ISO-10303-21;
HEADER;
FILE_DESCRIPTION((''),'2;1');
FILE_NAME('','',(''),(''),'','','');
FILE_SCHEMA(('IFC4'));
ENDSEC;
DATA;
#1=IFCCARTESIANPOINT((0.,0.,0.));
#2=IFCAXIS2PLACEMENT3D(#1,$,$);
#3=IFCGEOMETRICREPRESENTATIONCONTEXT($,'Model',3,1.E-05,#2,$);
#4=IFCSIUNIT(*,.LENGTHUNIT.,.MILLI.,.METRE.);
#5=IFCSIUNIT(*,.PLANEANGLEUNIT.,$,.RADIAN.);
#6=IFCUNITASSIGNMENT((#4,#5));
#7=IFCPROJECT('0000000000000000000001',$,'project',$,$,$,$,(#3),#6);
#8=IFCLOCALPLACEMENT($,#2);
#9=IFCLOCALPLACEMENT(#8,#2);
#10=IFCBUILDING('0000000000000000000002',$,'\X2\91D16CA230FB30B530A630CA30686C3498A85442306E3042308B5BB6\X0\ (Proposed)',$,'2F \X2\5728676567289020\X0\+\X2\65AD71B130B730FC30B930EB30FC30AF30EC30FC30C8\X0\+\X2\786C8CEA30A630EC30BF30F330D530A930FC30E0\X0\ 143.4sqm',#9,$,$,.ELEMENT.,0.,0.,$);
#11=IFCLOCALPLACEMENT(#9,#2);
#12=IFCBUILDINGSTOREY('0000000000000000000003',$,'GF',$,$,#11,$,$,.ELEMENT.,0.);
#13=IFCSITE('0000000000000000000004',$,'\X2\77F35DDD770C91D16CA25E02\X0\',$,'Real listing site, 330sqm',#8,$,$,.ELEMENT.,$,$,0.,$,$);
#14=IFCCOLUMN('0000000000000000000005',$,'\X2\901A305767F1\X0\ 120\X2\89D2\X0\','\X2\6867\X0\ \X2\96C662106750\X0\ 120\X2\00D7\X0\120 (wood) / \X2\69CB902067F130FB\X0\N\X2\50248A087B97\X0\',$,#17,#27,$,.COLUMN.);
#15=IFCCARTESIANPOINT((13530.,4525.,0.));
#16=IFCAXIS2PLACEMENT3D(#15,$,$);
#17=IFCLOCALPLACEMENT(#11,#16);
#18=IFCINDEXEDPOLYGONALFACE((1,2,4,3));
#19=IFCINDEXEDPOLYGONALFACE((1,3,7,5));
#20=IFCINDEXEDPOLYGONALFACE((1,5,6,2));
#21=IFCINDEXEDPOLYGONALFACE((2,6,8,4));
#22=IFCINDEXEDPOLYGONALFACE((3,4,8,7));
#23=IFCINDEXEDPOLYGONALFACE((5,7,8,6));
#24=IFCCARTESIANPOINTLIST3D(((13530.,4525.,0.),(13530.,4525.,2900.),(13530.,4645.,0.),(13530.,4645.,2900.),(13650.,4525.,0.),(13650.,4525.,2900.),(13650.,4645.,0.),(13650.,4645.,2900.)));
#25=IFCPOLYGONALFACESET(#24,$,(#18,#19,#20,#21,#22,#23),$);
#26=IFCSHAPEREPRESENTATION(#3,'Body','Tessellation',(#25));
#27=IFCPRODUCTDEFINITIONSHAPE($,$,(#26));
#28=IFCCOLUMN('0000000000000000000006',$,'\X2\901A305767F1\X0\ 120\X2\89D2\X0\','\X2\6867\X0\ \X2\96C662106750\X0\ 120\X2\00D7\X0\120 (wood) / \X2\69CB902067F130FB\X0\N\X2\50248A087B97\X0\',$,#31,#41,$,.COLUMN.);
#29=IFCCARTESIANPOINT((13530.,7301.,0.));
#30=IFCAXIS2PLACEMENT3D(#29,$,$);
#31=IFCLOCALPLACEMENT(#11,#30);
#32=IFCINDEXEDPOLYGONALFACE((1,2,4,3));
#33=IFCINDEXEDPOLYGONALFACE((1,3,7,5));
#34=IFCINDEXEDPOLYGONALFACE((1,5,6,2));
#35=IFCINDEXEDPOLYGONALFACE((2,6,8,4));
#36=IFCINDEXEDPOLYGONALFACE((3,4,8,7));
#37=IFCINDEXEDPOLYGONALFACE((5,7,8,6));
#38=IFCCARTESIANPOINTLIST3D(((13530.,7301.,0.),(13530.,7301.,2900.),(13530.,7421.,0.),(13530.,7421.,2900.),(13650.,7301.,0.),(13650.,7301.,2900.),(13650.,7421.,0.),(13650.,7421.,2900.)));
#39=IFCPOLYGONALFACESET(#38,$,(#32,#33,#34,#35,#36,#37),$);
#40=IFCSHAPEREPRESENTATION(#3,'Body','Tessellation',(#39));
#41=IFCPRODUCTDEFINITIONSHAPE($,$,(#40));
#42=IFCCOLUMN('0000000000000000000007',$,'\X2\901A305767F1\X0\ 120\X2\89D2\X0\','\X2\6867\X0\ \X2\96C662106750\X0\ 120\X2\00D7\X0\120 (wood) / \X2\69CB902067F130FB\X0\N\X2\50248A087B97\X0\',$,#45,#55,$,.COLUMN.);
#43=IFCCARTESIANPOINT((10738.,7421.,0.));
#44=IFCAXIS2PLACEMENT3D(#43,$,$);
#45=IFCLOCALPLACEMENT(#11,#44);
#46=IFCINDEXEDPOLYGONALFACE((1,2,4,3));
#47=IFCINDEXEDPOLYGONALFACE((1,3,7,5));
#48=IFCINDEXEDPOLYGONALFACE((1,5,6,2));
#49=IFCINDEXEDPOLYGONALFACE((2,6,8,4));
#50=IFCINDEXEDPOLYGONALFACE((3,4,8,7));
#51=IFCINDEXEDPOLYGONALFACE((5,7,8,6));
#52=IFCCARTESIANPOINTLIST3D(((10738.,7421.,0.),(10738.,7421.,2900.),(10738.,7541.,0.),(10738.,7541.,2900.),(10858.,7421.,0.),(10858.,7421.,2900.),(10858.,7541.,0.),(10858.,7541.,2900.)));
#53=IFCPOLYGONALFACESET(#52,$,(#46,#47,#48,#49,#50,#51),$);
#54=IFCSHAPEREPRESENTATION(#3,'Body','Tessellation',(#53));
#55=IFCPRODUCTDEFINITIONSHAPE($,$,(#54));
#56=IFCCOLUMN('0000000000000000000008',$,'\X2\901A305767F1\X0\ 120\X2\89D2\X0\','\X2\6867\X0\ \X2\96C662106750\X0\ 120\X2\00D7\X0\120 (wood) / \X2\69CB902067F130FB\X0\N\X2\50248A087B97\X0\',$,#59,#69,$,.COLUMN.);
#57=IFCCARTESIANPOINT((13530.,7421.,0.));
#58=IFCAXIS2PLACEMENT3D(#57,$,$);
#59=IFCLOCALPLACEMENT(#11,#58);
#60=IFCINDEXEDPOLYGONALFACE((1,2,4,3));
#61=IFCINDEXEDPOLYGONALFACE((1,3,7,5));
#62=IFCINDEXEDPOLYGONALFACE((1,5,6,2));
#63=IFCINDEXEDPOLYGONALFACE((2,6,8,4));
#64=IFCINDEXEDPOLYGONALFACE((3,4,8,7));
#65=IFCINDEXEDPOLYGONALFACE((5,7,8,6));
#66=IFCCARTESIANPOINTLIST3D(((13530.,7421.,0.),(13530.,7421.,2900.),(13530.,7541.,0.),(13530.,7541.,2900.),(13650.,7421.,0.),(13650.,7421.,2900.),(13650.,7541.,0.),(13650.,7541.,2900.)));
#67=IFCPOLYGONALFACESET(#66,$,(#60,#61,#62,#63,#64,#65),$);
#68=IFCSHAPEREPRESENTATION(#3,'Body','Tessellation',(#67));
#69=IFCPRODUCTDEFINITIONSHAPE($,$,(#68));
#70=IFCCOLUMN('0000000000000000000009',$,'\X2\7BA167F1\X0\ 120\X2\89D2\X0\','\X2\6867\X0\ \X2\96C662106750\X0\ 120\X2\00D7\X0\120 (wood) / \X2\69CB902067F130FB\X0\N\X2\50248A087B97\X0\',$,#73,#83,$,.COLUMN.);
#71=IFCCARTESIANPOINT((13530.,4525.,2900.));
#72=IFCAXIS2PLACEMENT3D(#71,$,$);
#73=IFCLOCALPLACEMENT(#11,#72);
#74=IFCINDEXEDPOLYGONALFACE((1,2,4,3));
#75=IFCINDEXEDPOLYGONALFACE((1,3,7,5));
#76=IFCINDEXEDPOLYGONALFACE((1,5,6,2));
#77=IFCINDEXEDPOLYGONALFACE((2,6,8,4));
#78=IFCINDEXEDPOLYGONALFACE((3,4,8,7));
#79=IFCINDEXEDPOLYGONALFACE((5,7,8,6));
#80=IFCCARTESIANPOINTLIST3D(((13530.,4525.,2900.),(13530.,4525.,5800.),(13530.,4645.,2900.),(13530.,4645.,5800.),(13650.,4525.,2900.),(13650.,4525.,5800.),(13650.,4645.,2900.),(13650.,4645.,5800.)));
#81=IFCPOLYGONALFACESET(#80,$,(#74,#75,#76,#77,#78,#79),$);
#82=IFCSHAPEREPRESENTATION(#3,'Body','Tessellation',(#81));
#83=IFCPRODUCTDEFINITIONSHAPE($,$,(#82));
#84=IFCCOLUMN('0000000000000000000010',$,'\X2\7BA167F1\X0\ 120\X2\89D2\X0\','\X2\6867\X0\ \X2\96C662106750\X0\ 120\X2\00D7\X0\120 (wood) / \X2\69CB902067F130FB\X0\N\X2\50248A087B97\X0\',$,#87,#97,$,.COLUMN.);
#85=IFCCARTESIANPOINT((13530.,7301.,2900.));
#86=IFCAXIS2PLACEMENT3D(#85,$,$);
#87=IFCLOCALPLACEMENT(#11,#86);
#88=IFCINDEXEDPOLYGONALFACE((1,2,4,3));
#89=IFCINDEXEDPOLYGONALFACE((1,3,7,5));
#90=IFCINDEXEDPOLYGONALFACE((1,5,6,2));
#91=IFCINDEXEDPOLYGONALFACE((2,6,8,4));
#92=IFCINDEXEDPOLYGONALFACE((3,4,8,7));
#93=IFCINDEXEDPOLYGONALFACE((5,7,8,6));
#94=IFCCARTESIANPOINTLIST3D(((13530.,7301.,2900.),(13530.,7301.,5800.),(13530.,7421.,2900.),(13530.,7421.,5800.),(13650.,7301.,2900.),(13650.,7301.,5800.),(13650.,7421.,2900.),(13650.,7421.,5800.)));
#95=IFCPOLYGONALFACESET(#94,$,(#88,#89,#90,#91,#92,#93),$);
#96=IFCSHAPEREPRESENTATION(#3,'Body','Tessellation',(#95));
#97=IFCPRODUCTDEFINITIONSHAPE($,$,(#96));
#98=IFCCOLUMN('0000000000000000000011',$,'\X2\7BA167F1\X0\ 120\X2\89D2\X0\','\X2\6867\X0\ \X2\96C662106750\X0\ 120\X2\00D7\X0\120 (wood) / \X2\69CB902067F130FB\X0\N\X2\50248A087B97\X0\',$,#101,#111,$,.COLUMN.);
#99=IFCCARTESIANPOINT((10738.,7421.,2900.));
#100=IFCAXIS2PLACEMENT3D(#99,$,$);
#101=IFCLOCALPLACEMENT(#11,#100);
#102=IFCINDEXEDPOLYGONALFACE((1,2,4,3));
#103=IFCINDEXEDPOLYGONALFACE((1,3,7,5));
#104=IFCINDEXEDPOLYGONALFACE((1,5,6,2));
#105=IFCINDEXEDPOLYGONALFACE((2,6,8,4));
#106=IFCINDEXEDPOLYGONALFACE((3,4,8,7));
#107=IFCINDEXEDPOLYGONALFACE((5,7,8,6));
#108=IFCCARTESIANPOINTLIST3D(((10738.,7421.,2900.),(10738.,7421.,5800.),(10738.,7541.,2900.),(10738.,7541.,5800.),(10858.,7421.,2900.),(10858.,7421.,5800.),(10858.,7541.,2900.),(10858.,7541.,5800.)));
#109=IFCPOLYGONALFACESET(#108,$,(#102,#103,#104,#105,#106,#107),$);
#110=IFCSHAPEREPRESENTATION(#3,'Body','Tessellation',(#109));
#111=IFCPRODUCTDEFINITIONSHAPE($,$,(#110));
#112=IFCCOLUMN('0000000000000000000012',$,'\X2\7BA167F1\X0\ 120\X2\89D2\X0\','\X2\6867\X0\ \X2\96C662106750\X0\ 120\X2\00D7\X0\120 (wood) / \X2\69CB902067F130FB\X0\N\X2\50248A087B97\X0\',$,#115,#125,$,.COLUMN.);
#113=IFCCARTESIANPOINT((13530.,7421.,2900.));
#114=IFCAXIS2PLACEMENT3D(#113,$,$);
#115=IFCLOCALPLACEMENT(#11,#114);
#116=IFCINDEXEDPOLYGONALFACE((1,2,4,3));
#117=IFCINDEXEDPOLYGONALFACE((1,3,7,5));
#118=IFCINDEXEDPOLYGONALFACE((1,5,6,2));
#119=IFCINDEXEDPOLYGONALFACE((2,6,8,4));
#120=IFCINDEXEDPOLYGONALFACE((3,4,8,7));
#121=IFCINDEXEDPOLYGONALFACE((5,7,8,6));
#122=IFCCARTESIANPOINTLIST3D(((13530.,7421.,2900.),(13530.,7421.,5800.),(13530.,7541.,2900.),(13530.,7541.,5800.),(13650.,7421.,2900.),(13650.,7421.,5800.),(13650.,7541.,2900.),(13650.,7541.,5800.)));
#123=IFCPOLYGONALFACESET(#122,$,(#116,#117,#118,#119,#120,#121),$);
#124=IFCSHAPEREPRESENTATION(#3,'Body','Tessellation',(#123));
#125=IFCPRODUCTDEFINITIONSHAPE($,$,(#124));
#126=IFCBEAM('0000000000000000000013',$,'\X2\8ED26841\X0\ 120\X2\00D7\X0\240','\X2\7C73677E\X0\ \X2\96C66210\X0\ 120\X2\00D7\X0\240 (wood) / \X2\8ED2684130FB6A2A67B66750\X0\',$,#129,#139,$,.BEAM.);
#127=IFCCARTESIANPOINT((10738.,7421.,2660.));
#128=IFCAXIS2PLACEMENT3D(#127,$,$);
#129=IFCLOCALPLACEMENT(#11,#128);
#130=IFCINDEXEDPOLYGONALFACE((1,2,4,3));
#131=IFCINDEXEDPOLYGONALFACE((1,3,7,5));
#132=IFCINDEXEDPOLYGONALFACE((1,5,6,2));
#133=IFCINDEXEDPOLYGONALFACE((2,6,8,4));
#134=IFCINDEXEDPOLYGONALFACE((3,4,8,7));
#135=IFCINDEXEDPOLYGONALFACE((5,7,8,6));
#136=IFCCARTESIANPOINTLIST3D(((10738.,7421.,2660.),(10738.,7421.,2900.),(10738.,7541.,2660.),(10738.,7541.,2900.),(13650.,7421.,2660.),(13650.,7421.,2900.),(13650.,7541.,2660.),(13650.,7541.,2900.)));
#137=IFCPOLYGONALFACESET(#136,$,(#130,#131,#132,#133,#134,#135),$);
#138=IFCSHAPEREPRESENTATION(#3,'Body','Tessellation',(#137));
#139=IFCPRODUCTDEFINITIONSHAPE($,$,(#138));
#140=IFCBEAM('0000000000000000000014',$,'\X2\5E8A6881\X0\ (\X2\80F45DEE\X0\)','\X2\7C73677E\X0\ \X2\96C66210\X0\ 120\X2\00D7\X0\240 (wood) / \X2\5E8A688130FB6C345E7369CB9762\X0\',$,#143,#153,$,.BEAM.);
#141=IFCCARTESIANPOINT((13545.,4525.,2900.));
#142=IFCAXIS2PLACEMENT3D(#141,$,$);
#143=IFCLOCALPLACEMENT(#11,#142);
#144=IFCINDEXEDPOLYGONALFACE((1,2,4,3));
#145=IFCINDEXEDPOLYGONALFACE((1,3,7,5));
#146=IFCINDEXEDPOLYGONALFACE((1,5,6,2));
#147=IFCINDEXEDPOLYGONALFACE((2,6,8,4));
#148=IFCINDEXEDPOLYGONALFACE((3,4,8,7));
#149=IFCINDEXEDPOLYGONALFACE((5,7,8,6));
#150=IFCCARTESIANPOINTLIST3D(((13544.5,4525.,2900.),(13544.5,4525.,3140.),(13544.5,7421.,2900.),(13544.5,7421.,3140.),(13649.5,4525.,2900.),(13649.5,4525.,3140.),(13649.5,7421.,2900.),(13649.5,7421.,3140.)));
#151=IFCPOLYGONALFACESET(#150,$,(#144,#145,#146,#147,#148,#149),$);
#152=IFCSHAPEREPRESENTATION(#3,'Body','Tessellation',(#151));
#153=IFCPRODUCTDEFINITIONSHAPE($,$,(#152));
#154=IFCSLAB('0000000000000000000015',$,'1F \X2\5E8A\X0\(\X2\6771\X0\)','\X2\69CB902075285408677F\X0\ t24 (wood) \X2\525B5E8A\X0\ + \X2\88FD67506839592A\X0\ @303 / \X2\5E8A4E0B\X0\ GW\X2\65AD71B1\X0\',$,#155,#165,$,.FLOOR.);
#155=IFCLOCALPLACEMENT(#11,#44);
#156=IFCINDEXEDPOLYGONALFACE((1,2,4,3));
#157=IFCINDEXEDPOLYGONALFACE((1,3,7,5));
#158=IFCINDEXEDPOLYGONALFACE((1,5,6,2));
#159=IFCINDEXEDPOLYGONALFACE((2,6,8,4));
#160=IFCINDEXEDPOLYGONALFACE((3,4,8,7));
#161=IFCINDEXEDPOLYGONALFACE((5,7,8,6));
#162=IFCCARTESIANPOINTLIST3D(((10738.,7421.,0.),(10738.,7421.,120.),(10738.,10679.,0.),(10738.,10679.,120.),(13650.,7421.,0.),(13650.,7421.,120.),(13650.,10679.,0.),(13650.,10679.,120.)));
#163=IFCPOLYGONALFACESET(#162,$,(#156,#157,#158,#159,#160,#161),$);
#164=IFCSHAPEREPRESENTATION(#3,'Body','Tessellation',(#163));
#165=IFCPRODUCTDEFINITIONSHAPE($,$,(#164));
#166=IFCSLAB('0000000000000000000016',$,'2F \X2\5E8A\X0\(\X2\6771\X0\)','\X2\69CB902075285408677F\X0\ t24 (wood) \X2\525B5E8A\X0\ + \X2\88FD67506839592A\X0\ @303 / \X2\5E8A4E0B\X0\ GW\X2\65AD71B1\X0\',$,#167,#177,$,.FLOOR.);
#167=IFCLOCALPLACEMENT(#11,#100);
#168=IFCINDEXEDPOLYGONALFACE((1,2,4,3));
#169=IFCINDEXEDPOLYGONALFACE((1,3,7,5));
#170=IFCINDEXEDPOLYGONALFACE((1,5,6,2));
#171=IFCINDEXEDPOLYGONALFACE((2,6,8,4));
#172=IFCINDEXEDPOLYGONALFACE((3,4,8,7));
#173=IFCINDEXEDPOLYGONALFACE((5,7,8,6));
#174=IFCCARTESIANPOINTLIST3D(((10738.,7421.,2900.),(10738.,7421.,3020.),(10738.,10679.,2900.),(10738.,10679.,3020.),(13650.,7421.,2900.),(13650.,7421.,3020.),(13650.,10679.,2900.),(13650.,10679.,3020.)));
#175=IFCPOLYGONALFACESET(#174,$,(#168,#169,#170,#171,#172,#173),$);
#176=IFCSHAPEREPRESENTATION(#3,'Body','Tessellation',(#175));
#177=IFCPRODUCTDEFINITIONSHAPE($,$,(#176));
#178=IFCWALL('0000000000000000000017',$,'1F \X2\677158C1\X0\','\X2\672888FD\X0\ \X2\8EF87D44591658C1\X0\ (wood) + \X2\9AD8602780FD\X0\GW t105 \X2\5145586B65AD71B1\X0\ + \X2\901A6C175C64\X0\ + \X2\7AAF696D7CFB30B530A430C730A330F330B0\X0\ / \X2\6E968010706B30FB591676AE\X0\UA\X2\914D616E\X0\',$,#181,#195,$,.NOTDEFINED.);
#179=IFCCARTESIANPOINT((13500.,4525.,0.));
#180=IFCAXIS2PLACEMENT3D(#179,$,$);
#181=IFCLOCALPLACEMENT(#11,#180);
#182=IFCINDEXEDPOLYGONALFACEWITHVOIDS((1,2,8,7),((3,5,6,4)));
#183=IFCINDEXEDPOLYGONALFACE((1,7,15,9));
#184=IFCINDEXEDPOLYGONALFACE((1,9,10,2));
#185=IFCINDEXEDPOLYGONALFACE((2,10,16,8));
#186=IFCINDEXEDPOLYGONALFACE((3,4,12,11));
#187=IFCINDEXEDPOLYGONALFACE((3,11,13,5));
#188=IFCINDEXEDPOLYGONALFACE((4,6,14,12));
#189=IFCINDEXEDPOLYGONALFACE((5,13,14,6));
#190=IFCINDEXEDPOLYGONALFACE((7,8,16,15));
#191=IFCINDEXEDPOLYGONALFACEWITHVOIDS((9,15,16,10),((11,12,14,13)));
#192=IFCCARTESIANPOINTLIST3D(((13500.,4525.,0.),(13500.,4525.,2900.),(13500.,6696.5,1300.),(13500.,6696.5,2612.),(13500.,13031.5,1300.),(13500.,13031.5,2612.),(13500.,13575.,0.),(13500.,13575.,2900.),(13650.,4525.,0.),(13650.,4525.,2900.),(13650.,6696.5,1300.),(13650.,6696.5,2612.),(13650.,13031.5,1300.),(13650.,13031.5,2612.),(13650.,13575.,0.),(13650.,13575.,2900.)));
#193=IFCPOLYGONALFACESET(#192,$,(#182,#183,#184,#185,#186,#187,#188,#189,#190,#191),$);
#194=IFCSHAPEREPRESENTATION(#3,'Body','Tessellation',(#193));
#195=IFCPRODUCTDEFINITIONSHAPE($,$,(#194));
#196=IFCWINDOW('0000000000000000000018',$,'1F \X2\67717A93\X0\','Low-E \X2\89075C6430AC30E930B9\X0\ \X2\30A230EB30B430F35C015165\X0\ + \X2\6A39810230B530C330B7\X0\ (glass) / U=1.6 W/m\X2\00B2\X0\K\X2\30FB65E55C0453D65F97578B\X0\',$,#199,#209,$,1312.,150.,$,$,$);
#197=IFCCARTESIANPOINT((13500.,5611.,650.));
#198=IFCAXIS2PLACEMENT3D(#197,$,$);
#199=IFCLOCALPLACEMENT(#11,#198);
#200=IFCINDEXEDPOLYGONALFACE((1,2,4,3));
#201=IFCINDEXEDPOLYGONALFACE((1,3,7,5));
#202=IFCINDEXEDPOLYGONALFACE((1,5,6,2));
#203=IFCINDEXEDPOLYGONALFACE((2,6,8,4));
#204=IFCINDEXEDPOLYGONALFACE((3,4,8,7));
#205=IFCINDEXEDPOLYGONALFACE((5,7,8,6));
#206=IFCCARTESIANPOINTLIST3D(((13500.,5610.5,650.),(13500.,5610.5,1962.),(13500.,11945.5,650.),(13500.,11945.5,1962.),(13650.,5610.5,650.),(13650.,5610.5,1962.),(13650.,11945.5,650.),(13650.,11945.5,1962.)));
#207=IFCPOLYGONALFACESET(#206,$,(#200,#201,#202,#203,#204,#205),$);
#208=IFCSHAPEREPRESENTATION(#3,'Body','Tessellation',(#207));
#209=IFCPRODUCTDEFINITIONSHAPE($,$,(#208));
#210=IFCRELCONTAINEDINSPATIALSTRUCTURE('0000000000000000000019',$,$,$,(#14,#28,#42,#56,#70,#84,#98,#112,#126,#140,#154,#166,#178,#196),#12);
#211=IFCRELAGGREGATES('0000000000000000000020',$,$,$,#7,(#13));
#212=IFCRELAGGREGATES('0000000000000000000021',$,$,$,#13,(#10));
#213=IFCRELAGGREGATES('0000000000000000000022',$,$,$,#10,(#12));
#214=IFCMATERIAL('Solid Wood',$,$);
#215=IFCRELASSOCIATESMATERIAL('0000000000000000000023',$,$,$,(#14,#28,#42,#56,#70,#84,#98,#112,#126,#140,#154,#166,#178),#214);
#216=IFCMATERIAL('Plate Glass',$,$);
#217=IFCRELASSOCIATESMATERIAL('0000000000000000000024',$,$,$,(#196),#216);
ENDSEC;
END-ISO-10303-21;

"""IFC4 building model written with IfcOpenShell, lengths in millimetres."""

from ifc_helpers import new_model, si_unit, frame, frame_2d, origin, place, context, project, spatial, rectangle, extrude, material, element, fill, save


model = new_model("IFC4")

# Units and contexts
model_context = context("Model", 3, precision=1e-05, world=origin())
ifc_project = project(units=[si_unit("LENGTHUNIT", "METRE", prefix="MILLI"), si_unit("PLANEANGLEUNIT", "RADIAN")], contexts=[model_context])

# Site, building, storey
site_placement = place(None, origin())
site = spatial("IfcSite", under=ifc_project, at=site_placement, Name="石川県金沢市", ObjectType="Real listing site, 330sqm", CompositionType="ELEMENT", RefElevation=0.0)
building_placement = place(site_placement, origin())
building = spatial("IfcBuilding", under=site, at=building_placement, Name="金沢・サウナと水風呂のある家 (Proposed)", ObjectType="2F 在来木造+断熱シースルークレート+硬質ウレタンフォーム 143.4sqm", CompositionType="ELEMENT", ElevationOfRefHeight=0.0, ElevationOfTerrain=0.0)
storey_placement = place(building_placement, origin())
storey = spatial("IfcBuildingStorey", under=building, at=storey_placement, Name="GF", CompositionType="ELEMENT", Elevation=0.0)

# Columns
ifc_material_1 = material(Name="Solid Wood")
column_1_placement = place(storey_placement, frame((13530.0, 4525.0, 0.0)))
element("IfcColumn", 1, at=column_1_placement, inside=storey, material=ifc_material_1, Name="通し柱 120角", Description="桧 集成材 120×120 (wood) / 構造柱・N値計算", PredefinedType="COLUMN", context=model_context, shape_type="SweptSolid", body=[
    extrude(rectangle(XDim=120.0, YDim=120.0, at=frame_2d((60.0, 60.0))), frame((13530.0, 4525.0, 0.0)), (0.0, 0.0, 1.0), 2900.0),
])
column_2_placement = place(storey_placement, frame((13530.0, 7301.0, 0.0)))
element("IfcColumn", 2, at=column_2_placement, inside=storey, material=ifc_material_1, Name="通し柱 120角", Description="桧 集成材 120×120 (wood) / 構造柱・N値計算", PredefinedType="COLUMN", context=model_context, shape_type="SweptSolid", body=[
    extrude(rectangle(XDim=120.0, YDim=120.0, at=frame_2d((60.0, 60.0))), frame((13530.0, 7301.0, 0.0)), (0.0, 0.0, 1.0), 2900.0),
])
column_3_placement = place(storey_placement, frame((10738.0, 7421.0, 0.0)))
element("IfcColumn", 3, at=column_3_placement, inside=storey, material=ifc_material_1, Name="通し柱 120角", Description="桧 集成材 120×120 (wood) / 構造柱・N値計算", PredefinedType="COLUMN", context=model_context, shape_type="SweptSolid", body=[
    extrude(rectangle(XDim=120.0, YDim=120.0, at=frame_2d((60.0, 60.0))), frame((10738.0, 7421.0, 0.0)), (0.0, 0.0, 1.0), 2900.0),
])
column_4_placement = place(storey_placement, frame((13530.0, 7421.0, 0.0)))
element("IfcColumn", 4, at=column_4_placement, inside=storey, material=ifc_material_1, Name="通し柱 120角", Description="桧 集成材 120×120 (wood) / 構造柱・N値計算", PredefinedType="COLUMN", context=model_context, shape_type="SweptSolid", body=[
    extrude(rectangle(XDim=120.0, YDim=120.0, at=frame_2d((60.0, 60.0))), frame((13530.0, 7421.0, 0.0)), (0.0, 0.0, 1.0), 2900.0),
])
column_5_placement = place(storey_placement, frame((13530.0, 4525.0, 2900.0)))
element("IfcColumn", 5, at=column_5_placement, inside=storey, material=ifc_material_1, Name="管柱 120角", Description="桧 集成材 120×120 (wood) / 構造柱・N値計算", PredefinedType="COLUMN", context=model_context, shape_type="SweptSolid", body=[
    extrude(rectangle(XDim=120.0, YDim=120.0, at=frame_2d((60.0, 60.0))), frame((13530.0, 4525.0, 2900.0)), (0.0, 0.0, 1.0), 2900.0),
])
column_6_placement = place(storey_placement, frame((13530.0, 7301.0, 2900.0)))
element("IfcColumn", 6, at=column_6_placement, inside=storey, material=ifc_material_1, Name="管柱 120角", Description="桧 集成材 120×120 (wood) / 構造柱・N値計算", PredefinedType="COLUMN", context=model_context, shape_type="SweptSolid", body=[
    extrude(rectangle(XDim=120.0, YDim=120.0, at=frame_2d((60.0, 60.0))), frame((13530.0, 7301.0, 2900.0)), (0.0, 0.0, 1.0), 2900.0),
])
column_7_placement = place(storey_placement, frame((10738.0, 7421.0, 2900.0)))
element("IfcColumn", 7, at=column_7_placement, inside=storey, material=ifc_material_1, Name="管柱 120角", Description="桧 集成材 120×120 (wood) / 構造柱・N値計算", PredefinedType="COLUMN", context=model_context, shape_type="SweptSolid", body=[
    extrude(rectangle(XDim=120.0, YDim=120.0, at=frame_2d((60.0, 60.0))), frame((10738.0, 7421.0, 2900.0)), (0.0, 0.0, 1.0), 2900.0),
])
column_8_placement = place(storey_placement, frame((13530.0, 7421.0, 2900.0)))
element("IfcColumn", 8, at=column_8_placement, inside=storey, material=ifc_material_1, Name="管柱 120角", Description="桧 集成材 120×120 (wood) / 構造柱・N値計算", PredefinedType="COLUMN", context=model_context, shape_type="SweptSolid", body=[
    extrude(rectangle(XDim=120.0, YDim=120.0, at=frame_2d((60.0, 60.0))), frame((13530.0, 7421.0, 2900.0)), (0.0, 0.0, 1.0), 2900.0),
])

# Beams
beam_1_placement = place(storey_placement, frame((10738.0, 7421.0, 2660.0)))
element("IfcBeam", 9, at=beam_1_placement, inside=storey, material=ifc_material_1, Name="軒桁 120×240", Description="米松 集成 120×240 (wood) / 軒桁・横架材", PredefinedType="BEAM", context=model_context, shape_type="SweptSolid", body=[
    extrude(rectangle(XDim=2912.0, YDim=120.0, at=frame_2d((1456.0, 60.0))), frame((10738.0, 7421.0, 2660.0)), (0.0, 0.0, 1.0), 240.0),
])
beam_2_placement = place(storey_placement, frame((13545.0, 4525.0, 2900.0)))
element("IfcBeam", 10, at=beam_2_placement, inside=storey, material=ifc_material_1, Name="床梁 (胴差)", Description="米松 集成 120×240 (wood) / 床梁・水平構面", PredefinedType="BEAM", context=model_context, shape_type="SweptSolid", body=[
    extrude(rectangle(XDim=105.0, YDim=2896.0, at=frame_2d((52.0, 1448.0))), frame((13545.0, 4525.0, 2900.0)), (0.0, 0.0, 1.0), 240.0),
])

# Slabs
slab_1_placement = place(storey_placement, frame((10738.0, 7421.0, 0.0)))
element("IfcSlab", 11, at=slab_1_placement, inside=storey, material=ifc_material_1, Name="1F 床(東)", Description="構造用合板 t24 (wood) 剛床 + 製材根太 @303 / 床下 GW断熱", PredefinedType="FLOOR", context=model_context, shape_type="SweptSolid", body=[
    extrude(rectangle(XDim=2912.0, YDim=3258.0, at=frame_2d((1456.0, 1629.0))), frame((10738.0, 7421.0, 0.0)), (0.0, 0.0, 1.0), 120.0),
])
slab_2_placement = place(storey_placement, frame((10738.0, 7421.0, 2900.0)))
element("IfcSlab", 12, at=slab_2_placement, inside=storey, material=ifc_material_1, Name="2F 床(東)", Description="構造用合板 t24 (wood) 剛床 + 製材根太 @303 / 床下 GW断熱", PredefinedType="FLOOR", context=model_context, shape_type="SweptSolid", body=[
    extrude(rectangle(XDim=2912.0, YDim=3258.0, at=frame_2d((1456.0, 1629.0))), frame((10738.0, 7421.0, 2900.0)), (0.0, 0.0, 1.0), 120.0),
])

# Wall, opening, window
wall_1_placement = place(storey_placement, frame((13500.0, 4525.0, 0.0)))
wall_1 = element("IfcWall", 13, at=wall_1_placement, inside=storey, material=ifc_material_1, Name="1F 東壁", Description="木製 軸組外壁 (wood) + 高性能GW t105 充填断熱 + 通気層 + 窯業系サイディング / 準耐火・外皮UA配慮", PredefinedType="NOTDEFINED", context=model_context, shape_type="SweptSolid", body=[
    extrude(rectangle(XDim=150.0, YDim=9050.0, at=frame_2d((75.0, 4525.0))), frame((13500.0, 4525.0, 0.0)), (0.0, 0.0, 1.0), 2900.0),
])
opening_1_placement = place(storey_placement, frame((13500.0, 5611.0, 650.0)))
opening_1 = element("IfcOpeningElement", 14, at=opening_1_placement, cuts=wall_1, PredefinedType="NOTDEFINED", context=model_context, shape_type="SweptSolid", body=[
    extrude(rectangle(XDim=150.0, YDim=6335.0, at=frame_2d((75.0, 3167.0))), frame((13500.0, 5611.0, 650.0)), (0.0, 0.0, 1.0), 1312.0),
])
ifc_material_2 = material(Name="Plate Glass")
window_1_placement = place(storey_placement, frame((13500.0, 5611.0, 650.0)))
window_1 = element("IfcWindow", 15, at=window_1_placement, inside=storey, material=ifc_material_2, Name="1F 東窓", Description="Low-E 複層ガラス アルゴン封入 + 樹脂サッシ (glass) / U=1.6 W/m²K・日射取得型", OverallHeight=1312.0, OverallWidth=150.0, context=model_context, shape_type="SweptSolid", body=[
    extrude(rectangle(XDim=150.0, YDim=6335.0, at=frame_2d((75.0, 3167.0))), frame((13500.0, 5611.0, 650.0)), (0.0, 0.0, 1.0), 1312.0),
])
fill(opening_1, window_1)

save(model, "model.ifc")
